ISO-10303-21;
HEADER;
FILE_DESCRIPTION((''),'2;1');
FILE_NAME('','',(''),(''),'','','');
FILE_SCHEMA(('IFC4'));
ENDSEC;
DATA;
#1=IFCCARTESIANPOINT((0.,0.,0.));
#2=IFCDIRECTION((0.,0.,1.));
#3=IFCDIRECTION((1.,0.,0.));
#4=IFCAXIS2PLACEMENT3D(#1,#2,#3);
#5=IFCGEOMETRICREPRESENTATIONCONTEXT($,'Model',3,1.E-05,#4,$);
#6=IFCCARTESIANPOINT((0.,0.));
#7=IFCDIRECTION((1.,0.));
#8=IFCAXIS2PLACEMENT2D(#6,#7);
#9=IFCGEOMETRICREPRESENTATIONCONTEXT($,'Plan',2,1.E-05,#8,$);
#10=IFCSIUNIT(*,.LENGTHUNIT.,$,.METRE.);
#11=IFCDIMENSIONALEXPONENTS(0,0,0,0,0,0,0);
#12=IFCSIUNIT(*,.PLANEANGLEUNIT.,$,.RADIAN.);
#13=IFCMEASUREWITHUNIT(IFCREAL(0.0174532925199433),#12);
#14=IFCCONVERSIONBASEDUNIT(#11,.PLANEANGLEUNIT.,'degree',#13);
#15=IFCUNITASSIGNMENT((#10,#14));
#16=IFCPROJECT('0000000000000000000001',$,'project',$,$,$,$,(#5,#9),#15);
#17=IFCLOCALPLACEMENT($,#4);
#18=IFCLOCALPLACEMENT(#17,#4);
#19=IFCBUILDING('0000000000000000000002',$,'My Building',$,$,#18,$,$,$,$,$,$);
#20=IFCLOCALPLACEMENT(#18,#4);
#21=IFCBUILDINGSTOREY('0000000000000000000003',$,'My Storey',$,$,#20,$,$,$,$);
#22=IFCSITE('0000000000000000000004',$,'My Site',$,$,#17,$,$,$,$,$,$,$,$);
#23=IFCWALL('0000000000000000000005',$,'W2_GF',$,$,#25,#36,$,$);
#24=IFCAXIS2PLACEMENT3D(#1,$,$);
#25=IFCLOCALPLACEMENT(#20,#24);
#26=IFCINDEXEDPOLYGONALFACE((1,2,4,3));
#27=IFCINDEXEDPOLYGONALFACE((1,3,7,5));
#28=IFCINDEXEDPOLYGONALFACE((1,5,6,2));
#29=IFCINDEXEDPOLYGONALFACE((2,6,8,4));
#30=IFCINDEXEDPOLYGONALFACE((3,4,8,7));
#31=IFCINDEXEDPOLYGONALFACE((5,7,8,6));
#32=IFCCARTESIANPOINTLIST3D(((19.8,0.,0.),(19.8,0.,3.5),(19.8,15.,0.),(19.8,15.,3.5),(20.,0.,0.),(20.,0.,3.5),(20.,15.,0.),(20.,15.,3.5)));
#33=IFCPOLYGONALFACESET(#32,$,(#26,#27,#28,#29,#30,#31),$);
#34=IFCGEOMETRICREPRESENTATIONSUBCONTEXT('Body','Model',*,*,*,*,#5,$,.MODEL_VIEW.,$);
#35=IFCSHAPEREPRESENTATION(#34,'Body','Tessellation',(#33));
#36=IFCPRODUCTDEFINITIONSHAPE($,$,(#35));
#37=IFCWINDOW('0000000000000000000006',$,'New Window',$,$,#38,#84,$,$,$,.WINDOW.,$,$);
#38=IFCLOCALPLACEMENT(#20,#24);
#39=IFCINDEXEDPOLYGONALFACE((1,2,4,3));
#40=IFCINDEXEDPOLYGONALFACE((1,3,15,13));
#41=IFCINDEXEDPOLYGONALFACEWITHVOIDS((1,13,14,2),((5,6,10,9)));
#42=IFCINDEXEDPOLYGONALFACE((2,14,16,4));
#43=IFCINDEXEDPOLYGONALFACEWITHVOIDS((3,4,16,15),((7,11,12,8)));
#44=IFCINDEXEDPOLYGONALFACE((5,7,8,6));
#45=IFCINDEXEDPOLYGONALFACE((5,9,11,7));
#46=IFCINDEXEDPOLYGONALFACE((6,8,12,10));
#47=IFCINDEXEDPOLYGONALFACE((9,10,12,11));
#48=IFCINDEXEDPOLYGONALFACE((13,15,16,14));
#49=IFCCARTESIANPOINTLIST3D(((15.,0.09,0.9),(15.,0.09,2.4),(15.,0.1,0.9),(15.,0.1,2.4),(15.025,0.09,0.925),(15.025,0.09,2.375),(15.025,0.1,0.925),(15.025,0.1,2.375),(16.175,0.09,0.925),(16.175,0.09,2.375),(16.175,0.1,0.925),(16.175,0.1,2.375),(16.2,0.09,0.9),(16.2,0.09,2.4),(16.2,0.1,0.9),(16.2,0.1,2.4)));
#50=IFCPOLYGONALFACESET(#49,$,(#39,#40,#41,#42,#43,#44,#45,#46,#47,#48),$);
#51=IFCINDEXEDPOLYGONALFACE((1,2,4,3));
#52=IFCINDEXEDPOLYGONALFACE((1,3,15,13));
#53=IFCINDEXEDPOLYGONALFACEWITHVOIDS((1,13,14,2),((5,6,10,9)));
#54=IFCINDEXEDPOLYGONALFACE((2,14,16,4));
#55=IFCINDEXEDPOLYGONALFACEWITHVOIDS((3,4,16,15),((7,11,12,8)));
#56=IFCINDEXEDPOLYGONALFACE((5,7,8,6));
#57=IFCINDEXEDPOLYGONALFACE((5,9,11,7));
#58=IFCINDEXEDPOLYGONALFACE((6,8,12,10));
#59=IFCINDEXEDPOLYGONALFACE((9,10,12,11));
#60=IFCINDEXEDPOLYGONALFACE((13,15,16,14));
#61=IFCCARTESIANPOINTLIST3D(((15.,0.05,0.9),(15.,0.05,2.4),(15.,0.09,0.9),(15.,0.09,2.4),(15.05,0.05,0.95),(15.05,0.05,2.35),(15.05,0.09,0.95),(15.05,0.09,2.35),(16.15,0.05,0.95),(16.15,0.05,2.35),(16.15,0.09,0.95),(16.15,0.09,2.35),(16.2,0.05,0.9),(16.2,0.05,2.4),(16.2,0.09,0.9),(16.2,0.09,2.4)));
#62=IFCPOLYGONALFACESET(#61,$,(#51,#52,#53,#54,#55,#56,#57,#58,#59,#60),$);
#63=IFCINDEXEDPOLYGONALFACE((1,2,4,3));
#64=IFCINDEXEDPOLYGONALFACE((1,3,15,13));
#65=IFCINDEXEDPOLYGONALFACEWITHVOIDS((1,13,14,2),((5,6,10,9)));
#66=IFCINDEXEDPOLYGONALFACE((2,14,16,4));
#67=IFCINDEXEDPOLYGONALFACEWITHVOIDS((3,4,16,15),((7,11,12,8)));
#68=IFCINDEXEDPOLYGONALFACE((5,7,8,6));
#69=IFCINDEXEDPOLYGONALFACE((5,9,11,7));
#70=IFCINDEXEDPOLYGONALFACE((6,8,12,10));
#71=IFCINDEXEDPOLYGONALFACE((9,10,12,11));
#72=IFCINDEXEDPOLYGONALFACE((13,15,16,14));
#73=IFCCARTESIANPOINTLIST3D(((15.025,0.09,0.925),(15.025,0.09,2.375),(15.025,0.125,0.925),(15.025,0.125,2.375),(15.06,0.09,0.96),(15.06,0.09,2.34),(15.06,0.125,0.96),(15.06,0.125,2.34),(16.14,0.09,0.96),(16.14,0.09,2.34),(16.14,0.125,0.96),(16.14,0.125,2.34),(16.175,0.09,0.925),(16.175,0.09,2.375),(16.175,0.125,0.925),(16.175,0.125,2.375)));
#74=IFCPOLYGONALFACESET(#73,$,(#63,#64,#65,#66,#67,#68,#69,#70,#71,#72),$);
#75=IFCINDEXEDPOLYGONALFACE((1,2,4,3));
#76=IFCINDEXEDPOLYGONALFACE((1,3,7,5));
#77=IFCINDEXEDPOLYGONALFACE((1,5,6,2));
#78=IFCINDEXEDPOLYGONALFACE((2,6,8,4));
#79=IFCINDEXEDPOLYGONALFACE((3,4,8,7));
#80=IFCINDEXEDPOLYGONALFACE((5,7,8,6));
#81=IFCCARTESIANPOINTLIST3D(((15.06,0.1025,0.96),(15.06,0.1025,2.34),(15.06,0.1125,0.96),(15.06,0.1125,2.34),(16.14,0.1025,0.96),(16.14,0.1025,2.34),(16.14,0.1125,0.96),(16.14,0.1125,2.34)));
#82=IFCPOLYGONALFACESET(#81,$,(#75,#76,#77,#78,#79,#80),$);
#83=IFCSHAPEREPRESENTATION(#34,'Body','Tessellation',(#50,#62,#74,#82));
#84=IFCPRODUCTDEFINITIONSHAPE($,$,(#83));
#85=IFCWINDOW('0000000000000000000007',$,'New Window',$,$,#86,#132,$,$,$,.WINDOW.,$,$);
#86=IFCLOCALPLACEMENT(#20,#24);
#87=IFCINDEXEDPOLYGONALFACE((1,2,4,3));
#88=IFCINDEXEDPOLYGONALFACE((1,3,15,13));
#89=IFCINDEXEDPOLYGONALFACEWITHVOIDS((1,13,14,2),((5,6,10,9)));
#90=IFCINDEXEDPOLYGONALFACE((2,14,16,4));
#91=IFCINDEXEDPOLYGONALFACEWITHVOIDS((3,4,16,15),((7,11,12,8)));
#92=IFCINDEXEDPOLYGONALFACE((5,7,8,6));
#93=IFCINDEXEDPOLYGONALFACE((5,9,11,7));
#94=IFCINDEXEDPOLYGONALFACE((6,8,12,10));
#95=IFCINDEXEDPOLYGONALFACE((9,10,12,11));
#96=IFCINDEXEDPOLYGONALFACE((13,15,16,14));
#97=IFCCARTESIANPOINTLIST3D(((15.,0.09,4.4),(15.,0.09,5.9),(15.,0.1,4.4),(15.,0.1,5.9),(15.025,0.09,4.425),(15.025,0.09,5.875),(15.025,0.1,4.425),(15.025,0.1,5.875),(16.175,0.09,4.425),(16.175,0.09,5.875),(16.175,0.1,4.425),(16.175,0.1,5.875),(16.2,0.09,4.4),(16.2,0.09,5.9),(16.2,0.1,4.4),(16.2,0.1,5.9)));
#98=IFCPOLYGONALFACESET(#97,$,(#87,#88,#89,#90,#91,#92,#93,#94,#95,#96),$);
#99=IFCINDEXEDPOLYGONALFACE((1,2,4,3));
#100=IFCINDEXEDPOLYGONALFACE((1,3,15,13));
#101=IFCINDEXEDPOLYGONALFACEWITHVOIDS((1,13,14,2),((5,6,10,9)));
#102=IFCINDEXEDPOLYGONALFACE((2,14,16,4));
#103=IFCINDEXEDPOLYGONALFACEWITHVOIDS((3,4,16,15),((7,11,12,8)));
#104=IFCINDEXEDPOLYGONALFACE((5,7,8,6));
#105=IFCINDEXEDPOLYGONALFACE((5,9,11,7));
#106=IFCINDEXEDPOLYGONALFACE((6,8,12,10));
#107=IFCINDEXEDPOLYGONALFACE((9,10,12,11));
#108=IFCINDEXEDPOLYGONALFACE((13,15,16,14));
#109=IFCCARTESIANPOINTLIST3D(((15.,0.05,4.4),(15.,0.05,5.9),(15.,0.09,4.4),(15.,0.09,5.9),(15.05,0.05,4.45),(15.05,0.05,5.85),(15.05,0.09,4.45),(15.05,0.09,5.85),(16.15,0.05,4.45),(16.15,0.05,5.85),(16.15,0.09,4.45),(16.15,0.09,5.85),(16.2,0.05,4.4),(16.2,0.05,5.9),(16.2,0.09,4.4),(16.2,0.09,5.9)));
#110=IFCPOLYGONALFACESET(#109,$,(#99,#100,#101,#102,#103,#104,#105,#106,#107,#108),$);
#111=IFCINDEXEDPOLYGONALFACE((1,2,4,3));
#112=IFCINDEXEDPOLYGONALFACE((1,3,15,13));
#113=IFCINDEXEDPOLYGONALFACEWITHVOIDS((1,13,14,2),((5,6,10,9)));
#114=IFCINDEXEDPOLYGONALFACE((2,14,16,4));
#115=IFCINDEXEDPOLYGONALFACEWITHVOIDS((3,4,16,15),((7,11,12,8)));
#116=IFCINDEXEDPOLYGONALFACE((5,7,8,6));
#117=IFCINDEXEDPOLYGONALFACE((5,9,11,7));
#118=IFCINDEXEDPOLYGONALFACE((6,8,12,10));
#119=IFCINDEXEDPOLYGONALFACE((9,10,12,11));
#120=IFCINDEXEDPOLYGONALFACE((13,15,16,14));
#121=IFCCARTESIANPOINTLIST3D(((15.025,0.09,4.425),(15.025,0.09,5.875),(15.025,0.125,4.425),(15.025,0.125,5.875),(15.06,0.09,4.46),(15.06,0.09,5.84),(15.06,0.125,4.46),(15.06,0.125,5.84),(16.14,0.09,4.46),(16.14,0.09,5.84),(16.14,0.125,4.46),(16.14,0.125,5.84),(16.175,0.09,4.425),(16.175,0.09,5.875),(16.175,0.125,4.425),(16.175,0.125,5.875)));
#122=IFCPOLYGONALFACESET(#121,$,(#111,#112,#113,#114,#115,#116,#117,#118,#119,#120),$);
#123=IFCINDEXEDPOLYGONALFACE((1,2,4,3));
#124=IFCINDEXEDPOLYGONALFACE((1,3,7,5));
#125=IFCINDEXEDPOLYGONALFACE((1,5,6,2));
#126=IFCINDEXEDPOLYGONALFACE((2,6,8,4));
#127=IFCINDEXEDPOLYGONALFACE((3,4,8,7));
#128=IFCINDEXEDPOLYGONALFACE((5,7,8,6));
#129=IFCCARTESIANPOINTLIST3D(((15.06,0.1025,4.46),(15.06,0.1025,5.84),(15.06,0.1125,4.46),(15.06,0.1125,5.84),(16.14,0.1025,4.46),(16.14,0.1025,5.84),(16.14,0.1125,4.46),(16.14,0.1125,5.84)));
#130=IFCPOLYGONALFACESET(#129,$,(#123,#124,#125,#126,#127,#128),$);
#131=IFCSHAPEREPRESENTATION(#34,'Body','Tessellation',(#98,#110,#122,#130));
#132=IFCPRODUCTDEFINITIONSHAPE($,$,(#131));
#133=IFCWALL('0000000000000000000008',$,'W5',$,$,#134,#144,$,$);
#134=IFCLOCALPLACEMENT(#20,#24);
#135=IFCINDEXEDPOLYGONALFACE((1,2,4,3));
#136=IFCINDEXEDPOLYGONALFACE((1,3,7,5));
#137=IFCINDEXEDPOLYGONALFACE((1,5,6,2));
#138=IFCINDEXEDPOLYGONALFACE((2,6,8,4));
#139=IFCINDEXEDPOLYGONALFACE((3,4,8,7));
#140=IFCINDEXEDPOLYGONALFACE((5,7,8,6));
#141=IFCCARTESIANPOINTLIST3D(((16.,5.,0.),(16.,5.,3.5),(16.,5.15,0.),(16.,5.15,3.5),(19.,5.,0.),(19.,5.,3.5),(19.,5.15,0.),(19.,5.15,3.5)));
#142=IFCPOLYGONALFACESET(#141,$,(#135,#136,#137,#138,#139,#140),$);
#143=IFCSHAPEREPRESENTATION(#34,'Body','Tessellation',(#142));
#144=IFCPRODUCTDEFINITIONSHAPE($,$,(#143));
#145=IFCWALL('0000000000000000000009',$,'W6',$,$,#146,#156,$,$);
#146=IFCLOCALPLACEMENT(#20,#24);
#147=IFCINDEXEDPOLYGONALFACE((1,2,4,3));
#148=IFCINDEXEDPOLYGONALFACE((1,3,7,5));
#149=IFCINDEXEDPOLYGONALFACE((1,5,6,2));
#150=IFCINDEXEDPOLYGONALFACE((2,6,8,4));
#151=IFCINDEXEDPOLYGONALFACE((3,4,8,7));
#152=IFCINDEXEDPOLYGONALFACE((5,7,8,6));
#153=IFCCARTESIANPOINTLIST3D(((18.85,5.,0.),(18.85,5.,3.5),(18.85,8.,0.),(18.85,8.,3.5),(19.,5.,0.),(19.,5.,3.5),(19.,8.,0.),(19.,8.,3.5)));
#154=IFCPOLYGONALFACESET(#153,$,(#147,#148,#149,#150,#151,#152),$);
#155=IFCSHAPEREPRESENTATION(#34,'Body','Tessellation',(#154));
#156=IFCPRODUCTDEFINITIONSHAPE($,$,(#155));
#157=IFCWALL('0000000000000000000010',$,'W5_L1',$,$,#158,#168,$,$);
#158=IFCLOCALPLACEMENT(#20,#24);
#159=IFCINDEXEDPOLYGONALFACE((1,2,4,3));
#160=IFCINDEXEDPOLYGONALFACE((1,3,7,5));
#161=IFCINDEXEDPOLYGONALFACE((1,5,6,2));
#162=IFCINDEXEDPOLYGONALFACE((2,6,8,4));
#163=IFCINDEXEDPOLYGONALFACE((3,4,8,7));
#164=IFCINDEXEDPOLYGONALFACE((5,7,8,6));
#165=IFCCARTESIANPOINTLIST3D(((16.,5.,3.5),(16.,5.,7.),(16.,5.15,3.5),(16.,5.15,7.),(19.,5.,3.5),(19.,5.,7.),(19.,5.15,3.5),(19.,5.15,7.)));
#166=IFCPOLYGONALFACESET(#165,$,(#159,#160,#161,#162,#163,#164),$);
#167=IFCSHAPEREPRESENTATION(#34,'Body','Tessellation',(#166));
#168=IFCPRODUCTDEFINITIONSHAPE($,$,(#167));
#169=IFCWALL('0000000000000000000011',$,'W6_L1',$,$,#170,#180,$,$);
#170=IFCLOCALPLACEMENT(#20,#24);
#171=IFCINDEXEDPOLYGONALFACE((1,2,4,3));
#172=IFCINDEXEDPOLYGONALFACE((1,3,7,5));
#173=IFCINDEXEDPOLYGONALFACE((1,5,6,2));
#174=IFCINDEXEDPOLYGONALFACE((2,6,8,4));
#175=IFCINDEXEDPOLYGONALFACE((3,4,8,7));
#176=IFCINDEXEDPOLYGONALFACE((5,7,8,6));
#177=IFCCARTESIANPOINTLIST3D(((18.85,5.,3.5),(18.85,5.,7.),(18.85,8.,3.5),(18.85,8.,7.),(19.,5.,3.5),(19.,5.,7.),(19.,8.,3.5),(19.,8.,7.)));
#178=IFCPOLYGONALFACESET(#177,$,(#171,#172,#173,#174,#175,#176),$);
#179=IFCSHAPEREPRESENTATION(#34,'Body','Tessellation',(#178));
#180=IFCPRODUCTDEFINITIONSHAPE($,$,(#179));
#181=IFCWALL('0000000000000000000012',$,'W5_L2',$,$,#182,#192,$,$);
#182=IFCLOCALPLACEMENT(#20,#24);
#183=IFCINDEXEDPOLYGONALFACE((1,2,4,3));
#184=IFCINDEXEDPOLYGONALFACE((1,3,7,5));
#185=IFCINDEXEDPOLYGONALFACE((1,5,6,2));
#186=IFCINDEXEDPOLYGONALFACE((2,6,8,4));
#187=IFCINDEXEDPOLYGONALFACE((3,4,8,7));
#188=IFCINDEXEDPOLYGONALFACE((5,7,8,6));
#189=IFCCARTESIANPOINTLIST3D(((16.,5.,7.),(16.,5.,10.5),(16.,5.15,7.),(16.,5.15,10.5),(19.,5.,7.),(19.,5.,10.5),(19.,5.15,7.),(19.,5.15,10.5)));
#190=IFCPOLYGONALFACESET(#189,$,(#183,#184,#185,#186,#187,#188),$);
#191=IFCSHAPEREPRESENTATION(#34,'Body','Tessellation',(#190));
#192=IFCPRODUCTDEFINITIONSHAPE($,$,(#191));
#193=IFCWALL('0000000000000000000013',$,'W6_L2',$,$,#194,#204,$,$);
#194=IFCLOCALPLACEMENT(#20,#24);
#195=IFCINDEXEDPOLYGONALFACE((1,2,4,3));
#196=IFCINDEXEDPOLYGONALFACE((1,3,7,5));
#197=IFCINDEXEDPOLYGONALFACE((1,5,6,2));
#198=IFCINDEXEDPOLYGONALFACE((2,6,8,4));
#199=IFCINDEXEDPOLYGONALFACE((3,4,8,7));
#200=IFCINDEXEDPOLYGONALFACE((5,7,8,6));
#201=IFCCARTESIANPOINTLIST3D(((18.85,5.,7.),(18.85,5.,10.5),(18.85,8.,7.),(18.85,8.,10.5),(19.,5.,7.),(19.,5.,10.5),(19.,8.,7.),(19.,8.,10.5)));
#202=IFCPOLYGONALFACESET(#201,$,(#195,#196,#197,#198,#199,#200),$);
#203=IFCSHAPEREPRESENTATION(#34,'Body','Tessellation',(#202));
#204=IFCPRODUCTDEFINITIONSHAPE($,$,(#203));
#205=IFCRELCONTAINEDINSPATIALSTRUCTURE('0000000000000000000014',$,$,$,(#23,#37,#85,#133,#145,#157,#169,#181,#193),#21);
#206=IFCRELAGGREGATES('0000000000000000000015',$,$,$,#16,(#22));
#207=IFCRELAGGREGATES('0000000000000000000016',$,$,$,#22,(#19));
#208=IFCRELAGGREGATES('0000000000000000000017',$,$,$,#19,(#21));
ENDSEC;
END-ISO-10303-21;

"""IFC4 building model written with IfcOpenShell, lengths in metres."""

from ifc_helpers import new_model, entity, si_unit, converted_unit, frame, origin_with_axes, origin_2d_with_axis, place, context, subcontext, project, spatial, line, indexed_curve, outline, extrude, element, save


model = new_model("IFC4")

# Units and contexts
model_context = context("Model", 3, precision=1e-05, world=origin_with_axes())
plan_context = context("Plan", 2, precision=1e-05, world=origin_2d_with_axis())
body_context = subcontext(model_context, "Body", "Model", "MODEL_VIEW")
ifc_project = project(units=[si_unit("LENGTHUNIT", "METRE"), converted_unit("PLANEANGLEUNIT", "degree", entity("IfcReal", 0.0174532925199433), si_unit("PLANEANGLEUNIT", "RADIAN"), dimensions=[0, 0, 0, 0, 0, 0, 0])], contexts=[model_context, plan_context])

# Site, building, storey
site_placement = place(None, origin_with_axes())
site = spatial("IfcSite", under=ifc_project, at=site_placement, Name="My Site")
building_placement = place(site_placement, origin_with_axes())
building = spatial("IfcBuilding", under=site, at=building_placement, Name="My Building")
storey_placement = place(building_placement, origin_with_axes())
storey = spatial("IfcBuildingStorey", under=building, at=storey_placement, Name="My Storey")

# Wall
for number, where, z_axis, x_axis, name in (
    (1, (20.0, 0.0, 0.0), (0.0, 0.0, 1.0), (0.0, 1.0, 0.0), "W2_GF"),
):
    element("IfcWall", number, at=place(storey_placement, frame(where, z_axis=z_axis, x_axis=x_axis)), inside=storey, Name=name, context=body_context, shape_type="SweptSolid", body=[
        extrude(outline(indexed_curve([(0.0, 0.0), (0.0, 0.2), (15.0, 0.2), (15.0, 0.0), (0.0, 0.0)], self_intersect=False)), origin_with_axes(), (0.0, 0.0, 1.0), 3.5),
    ])

# Windows
for number, where, z_axis, x_axis, name in (
    (2, (15.0, 0.0, 0.9), (0.0, 0.0, 1.0), (1.0, 0.0, 0.0), "New Window"),
    (3, (15.0, 0.0, 4.4), (0.0, 0.0, 1.0), (1.0, 0.0, 0.0), "New Window"),
):
    element("IfcWindow", number, at=place(storey_placement, frame(where, z_axis=z_axis, x_axis=x_axis)), inside=storey, Name=name, PredefinedType="WINDOW", context=body_context, shape_type="SweptSolid", body=[
        extrude(outline(indexed_curve([(0.0, 0.0), (1.2, 0.0), (1.2, 1.5), (0.0, 1.5)], segments=[line(1, 2, 3, 4, 1)]), holes=[indexed_curve([(0.025, 0.025), (1.175, 0.025), (1.175, 1.475), (0.025, 1.475)], segments=[line(1, 2, 3, 4, 1)])]), frame((0.0, 0.09, 0.0), z_axis=(0.0, -1.0, 0.0), x_axis=(1.0, 0.0, 0.0)), (0.0, 0.0, -1.0), 0.01),
        extrude(outline(indexed_curve([(0.0, 0.0), (1.2, 0.0), (1.2, 1.5), (0.0, 1.5)], segments=[line(1, 2, 3, 4, 1)]), holes=[indexed_curve([(0.05, 0.05), (1.15, 0.05), (1.15, 1.45), (0.05, 1.45)], segments=[line(1, 2, 3, 4, 1)])]), frame((0.0, 0.05, 0.0), z_axis=(0.0, -1.0, 0.0), x_axis=(1.0, 0.0, 0.0)), (0.0, 0.0, -1.0), 0.04),
        extrude(outline(indexed_curve([(0.0, 0.0), (1.15, 0.0), (1.15, 1.45), (0.0, 1.45)], segments=[line(1, 2, 3, 4, 1)]), holes=[indexed_curve([(0.035, 0.035), (1.115, 0.035), (1.115, 1.415), (0.035, 1.415)], segments=[line(1, 2, 3, 4, 1)])]), frame((0.025, 0.09, 0.025), z_axis=(0.0, -1.0, 0.0), x_axis=(1.0, 0.0, 0.0)), (0.0, 0.0, -1.0), 0.035),
        extrude(outline(indexed_curve([(0.035, 0.035), (1.115, 0.035), (1.115, 1.415), (0.035, 1.415)], segments=[line(1, 2, 3, 4, 1)])), frame((0.025, 0.1025, 0.025), z_axis=(0.0, -1.0, 0.0), x_axis=(1.0, 0.0, 0.0)), (0.0, 0.0, -1.0), 0.01),
    ])

# Walls
for number, where, z_axis, x_axis, name in (
    (4, (16.0, 5.0, 0.0), (0.0, 0.0, 1.0), (1.0, 0.0, 0.0), "W5"),
    (5, (19.0, 5.0, 0.0), (0.0, 0.0, 1.0), (0.0, 1.0, 0.0), "W6"),
    (6, (16.0, 5.0, 3.5), (0.0, 0.0, 1.0), (1.0, 0.0, 0.0), "W5_L1"),
    (7, (19.0, 5.0, 3.5), (0.0, 0.0, 1.0), (0.0, 1.0, 0.0), "W6_L1"),
    (8, (16.0, 5.0, 7.0), (0.0, 0.0, 1.0), (1.0, 0.0, 0.0), "W5_L2"),
    (9, (19.0, 5.0, 7.0), (0.0, 0.0, 1.0), (0.0, 1.0, 0.0), "W6_L2"),
):
    element("IfcWall", number, at=place(storey_placement, frame(where, z_axis=z_axis, x_axis=x_axis)), inside=storey, Name=name, context=body_context, shape_type="SweptSolid", body=[
        extrude(outline(indexed_curve([(0.0, 0.0), (0.0, 0.15), (3.0, 0.15), (3.0, 0.0), (0.0, 0.0)], self_intersect=False)), origin_with_axes(), (0.0, 0.0, 1.0), 3.5),
    ])

save(model, "model.ifc")
